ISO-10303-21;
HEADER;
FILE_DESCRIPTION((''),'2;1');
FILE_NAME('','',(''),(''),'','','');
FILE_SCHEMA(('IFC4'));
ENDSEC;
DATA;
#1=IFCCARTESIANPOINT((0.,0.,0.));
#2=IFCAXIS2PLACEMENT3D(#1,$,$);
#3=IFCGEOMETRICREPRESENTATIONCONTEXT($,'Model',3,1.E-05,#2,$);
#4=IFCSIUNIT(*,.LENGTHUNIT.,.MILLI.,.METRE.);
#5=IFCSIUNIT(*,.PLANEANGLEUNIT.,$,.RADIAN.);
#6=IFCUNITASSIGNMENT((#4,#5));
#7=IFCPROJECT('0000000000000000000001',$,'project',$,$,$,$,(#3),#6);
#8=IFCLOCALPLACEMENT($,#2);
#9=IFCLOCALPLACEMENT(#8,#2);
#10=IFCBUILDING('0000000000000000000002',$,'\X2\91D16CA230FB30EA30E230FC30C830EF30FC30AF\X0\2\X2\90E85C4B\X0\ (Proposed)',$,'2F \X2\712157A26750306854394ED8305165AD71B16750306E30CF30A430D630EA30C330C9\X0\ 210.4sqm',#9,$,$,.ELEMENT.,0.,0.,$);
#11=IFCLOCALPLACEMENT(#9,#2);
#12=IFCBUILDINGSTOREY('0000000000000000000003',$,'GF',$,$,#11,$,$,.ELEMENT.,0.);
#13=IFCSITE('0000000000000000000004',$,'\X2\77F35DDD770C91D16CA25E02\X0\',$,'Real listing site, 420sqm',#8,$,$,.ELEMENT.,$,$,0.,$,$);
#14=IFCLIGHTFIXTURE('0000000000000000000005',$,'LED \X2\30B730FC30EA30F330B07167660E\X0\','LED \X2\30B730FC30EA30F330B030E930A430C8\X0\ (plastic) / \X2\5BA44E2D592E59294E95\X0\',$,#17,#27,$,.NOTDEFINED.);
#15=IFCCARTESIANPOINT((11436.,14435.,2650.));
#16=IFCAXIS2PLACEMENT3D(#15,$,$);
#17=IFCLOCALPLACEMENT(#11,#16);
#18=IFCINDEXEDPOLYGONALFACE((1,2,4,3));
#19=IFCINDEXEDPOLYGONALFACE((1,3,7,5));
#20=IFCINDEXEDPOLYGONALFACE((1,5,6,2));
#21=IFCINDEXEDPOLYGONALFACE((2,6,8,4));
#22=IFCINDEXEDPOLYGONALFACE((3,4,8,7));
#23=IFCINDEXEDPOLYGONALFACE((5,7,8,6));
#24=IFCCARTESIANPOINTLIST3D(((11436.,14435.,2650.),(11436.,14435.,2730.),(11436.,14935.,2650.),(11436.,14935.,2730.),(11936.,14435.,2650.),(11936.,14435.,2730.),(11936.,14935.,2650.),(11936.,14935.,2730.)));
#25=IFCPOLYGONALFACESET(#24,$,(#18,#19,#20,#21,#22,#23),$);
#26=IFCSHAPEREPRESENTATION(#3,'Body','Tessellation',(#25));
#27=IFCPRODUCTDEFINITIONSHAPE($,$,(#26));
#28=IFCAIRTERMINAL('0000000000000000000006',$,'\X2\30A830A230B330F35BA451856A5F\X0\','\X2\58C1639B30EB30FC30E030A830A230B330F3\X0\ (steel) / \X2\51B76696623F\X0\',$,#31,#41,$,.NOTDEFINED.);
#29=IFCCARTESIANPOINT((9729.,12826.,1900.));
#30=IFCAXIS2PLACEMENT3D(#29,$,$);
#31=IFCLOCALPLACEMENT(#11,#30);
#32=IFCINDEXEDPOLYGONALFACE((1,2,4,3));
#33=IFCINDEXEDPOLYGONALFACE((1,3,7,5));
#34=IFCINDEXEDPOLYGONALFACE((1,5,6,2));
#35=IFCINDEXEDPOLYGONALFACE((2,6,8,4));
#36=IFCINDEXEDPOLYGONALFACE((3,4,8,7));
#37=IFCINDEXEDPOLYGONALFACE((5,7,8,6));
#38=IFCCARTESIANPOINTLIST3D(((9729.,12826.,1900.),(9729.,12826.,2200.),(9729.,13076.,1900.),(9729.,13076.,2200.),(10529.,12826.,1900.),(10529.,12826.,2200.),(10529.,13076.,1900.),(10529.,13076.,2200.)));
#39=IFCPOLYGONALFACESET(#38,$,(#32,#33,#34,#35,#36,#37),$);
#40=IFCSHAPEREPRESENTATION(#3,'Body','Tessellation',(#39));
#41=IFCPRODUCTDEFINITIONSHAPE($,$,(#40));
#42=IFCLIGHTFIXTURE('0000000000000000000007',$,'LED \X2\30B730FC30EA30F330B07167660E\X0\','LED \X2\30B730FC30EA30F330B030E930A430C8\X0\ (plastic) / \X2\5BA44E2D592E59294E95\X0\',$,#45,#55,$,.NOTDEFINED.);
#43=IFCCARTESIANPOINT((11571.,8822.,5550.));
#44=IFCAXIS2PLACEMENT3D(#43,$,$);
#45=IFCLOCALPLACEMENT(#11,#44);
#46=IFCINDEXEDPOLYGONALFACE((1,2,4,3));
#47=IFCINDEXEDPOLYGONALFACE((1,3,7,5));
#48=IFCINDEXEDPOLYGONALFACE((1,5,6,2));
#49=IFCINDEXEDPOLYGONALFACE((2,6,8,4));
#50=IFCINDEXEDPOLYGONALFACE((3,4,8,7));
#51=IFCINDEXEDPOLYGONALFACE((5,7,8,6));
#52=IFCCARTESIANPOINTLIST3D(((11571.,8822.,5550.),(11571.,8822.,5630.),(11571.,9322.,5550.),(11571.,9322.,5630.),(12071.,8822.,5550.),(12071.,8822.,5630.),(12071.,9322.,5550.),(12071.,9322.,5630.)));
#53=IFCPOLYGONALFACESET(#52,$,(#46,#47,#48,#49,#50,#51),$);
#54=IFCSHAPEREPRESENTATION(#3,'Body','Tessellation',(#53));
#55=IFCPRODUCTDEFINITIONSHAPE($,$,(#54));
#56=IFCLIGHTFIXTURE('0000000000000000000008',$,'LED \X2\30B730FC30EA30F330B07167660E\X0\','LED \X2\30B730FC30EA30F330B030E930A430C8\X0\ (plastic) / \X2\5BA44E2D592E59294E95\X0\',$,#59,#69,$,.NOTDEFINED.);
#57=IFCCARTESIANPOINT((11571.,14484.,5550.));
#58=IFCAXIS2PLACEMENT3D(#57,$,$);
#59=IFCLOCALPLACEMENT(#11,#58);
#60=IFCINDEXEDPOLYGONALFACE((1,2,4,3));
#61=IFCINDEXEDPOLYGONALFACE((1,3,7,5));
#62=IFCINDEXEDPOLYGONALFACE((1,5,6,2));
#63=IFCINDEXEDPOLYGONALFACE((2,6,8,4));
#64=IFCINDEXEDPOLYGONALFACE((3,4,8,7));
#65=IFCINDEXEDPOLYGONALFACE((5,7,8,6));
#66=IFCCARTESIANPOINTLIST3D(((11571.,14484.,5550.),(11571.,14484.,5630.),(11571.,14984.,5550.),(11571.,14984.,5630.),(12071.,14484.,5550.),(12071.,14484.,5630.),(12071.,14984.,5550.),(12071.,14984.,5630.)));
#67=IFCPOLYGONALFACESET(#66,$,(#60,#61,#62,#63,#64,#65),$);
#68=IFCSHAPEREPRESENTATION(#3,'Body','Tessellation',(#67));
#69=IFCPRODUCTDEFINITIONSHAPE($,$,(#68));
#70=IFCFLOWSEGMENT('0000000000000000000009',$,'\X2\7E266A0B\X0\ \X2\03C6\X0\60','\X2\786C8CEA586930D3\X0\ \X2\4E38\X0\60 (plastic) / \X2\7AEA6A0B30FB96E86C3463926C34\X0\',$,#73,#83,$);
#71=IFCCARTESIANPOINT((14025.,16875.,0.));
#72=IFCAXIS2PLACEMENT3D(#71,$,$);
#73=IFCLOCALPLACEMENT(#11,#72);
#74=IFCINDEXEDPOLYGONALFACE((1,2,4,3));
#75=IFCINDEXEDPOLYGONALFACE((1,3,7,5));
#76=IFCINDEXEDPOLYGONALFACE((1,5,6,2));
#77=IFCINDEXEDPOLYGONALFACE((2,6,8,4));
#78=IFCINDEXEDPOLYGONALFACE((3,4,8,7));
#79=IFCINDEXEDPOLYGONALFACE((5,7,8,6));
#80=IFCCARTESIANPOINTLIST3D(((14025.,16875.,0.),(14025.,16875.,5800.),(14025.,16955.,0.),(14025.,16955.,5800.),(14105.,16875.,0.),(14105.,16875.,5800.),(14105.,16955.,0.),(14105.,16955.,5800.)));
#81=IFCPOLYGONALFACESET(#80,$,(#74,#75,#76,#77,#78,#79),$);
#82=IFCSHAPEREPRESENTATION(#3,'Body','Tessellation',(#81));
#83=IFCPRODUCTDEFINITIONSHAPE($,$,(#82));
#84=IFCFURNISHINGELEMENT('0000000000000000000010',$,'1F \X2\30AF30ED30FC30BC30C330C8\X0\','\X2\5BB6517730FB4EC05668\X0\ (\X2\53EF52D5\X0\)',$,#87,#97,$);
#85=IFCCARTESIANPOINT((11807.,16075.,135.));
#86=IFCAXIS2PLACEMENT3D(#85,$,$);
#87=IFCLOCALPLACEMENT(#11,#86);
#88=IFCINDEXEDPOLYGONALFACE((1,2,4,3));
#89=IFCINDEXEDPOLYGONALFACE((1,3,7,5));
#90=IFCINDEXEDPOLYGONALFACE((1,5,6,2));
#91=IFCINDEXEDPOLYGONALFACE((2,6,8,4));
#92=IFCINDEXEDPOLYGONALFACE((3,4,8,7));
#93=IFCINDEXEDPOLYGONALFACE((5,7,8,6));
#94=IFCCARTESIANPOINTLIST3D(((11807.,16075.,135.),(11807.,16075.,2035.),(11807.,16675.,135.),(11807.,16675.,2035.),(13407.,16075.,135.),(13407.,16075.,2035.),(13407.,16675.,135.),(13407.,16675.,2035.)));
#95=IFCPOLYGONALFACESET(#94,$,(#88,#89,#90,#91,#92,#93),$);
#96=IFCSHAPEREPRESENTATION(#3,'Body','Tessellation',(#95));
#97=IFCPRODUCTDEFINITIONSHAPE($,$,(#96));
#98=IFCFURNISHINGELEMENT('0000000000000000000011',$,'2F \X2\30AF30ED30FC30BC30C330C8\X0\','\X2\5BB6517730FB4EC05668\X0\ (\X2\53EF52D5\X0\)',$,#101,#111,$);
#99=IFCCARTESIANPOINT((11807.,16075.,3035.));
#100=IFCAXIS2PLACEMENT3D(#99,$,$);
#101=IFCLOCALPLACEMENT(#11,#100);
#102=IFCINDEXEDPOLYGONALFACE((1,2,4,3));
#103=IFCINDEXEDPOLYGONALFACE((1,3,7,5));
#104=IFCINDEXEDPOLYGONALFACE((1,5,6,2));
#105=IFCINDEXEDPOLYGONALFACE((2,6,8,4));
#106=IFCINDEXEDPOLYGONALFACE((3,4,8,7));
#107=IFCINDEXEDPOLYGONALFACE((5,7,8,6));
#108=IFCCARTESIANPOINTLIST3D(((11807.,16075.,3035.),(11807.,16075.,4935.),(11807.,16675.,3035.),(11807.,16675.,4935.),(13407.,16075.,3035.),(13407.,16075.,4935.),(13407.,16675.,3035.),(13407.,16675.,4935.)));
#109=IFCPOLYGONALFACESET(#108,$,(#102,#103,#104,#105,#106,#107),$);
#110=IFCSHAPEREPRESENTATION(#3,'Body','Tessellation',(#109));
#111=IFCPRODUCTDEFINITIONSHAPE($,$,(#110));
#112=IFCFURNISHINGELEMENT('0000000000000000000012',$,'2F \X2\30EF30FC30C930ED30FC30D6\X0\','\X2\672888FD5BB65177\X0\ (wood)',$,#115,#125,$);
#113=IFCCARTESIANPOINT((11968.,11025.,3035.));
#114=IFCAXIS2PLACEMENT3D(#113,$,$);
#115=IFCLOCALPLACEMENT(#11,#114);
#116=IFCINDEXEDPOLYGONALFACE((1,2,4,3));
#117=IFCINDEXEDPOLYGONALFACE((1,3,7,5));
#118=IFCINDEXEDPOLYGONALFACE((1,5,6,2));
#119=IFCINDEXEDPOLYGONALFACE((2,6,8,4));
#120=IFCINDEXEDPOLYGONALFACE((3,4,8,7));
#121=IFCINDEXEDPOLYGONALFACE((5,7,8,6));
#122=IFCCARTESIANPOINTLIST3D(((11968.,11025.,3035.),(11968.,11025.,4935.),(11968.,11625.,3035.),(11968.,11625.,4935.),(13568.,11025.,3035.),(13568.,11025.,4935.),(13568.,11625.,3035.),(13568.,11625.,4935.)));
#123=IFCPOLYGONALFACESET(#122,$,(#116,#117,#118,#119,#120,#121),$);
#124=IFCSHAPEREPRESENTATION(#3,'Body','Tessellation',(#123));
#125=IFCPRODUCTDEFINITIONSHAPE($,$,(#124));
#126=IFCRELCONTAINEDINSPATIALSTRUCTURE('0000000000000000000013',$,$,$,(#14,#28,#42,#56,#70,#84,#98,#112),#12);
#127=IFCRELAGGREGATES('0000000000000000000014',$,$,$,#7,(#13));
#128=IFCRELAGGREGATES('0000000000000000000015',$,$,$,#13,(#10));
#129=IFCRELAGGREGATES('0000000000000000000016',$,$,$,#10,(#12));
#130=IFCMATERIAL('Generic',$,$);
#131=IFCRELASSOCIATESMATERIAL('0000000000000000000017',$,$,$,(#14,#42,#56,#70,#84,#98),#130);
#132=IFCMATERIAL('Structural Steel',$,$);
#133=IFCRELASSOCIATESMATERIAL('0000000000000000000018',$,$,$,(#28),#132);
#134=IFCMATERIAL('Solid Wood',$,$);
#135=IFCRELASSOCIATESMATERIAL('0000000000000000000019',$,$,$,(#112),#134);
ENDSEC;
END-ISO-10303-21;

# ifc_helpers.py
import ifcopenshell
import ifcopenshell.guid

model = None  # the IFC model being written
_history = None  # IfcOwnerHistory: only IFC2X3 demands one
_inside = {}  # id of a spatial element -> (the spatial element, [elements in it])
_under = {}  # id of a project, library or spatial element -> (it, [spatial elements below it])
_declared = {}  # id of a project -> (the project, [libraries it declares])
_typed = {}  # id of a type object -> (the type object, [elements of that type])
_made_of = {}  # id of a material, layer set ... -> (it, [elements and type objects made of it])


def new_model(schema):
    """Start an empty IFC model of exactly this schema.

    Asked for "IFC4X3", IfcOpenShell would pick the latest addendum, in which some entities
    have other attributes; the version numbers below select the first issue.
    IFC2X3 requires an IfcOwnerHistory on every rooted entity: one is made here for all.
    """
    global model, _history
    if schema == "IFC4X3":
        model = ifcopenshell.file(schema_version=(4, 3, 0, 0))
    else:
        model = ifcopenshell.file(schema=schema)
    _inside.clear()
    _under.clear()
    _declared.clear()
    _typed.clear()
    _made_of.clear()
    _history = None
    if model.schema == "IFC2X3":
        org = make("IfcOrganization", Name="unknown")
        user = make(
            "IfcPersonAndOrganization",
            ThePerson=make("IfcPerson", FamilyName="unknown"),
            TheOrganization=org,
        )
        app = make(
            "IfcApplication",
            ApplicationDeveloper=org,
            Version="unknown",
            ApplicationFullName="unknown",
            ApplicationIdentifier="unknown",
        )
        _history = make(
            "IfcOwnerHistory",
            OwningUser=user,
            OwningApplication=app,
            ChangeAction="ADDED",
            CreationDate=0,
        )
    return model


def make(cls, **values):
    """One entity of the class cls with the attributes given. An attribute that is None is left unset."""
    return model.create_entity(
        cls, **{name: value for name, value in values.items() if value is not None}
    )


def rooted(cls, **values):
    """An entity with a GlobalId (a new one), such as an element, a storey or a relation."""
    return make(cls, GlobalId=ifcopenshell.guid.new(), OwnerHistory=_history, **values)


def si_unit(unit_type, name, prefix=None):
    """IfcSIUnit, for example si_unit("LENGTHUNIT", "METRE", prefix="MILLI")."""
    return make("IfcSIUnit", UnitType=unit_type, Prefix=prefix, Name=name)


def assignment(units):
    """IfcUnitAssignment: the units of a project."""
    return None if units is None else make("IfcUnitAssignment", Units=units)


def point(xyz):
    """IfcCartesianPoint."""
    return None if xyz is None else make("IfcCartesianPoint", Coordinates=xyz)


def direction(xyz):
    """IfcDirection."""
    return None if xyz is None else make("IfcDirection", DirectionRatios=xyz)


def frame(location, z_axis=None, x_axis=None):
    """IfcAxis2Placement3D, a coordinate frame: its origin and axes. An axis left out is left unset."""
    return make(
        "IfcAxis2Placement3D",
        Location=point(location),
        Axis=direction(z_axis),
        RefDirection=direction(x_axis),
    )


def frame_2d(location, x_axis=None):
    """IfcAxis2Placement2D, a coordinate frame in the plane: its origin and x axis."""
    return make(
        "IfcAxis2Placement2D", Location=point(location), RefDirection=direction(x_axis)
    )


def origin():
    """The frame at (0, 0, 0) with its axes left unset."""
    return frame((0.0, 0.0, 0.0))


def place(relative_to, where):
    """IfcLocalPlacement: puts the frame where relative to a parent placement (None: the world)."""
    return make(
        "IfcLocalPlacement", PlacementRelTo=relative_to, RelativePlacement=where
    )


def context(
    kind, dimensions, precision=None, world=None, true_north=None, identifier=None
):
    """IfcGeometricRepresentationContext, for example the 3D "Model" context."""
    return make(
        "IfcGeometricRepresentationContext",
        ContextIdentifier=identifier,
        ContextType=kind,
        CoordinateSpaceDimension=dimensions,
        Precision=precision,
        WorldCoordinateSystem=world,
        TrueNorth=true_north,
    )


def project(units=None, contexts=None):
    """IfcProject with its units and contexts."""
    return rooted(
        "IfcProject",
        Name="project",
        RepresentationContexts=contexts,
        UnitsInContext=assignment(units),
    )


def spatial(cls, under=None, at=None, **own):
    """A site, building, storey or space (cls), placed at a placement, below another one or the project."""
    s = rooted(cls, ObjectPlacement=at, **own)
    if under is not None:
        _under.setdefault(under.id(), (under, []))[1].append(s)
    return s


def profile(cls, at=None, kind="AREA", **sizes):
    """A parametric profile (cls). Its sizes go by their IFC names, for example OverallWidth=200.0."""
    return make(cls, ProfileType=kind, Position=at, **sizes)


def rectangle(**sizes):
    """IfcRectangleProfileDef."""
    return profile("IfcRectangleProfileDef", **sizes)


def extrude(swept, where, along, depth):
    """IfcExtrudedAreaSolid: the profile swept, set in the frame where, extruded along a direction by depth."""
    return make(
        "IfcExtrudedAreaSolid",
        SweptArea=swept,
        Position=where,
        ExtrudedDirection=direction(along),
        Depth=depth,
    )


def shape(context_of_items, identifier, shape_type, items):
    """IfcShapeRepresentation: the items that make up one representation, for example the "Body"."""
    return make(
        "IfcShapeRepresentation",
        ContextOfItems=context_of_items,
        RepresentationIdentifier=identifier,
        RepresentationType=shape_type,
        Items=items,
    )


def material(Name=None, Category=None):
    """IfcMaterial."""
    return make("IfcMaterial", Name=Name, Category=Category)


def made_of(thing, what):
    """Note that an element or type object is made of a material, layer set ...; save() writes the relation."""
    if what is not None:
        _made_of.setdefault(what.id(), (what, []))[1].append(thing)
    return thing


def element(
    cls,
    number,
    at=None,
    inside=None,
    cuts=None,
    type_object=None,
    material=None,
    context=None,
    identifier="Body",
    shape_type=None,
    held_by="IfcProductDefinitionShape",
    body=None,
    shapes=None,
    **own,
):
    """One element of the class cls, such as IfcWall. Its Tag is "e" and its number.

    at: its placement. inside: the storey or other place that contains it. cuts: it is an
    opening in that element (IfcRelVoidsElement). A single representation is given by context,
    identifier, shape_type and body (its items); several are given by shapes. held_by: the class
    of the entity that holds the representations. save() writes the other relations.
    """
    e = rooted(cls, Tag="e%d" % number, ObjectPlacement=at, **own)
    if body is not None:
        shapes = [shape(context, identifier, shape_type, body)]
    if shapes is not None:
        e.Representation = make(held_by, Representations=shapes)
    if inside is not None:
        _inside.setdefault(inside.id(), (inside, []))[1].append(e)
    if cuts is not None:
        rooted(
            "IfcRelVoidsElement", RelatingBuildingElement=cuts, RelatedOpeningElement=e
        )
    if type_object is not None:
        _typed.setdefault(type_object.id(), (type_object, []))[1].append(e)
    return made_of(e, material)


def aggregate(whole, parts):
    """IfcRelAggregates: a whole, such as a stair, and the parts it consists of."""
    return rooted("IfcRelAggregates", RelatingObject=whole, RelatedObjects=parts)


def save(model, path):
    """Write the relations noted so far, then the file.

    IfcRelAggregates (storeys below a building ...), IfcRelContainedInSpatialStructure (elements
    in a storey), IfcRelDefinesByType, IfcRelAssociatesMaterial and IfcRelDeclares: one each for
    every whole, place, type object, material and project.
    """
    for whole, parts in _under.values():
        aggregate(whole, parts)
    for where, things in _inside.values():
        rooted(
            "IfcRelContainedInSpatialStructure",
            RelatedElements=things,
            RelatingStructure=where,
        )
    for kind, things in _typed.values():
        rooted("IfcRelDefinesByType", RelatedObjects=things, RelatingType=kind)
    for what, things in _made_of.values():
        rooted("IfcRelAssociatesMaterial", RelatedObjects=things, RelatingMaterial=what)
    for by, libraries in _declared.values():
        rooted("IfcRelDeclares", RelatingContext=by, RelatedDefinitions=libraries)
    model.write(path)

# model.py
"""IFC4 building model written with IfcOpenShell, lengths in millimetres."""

from ifc_helpers import new_model, si_unit, frame, frame_2d, origin, place, context, project, spatial, rectangle, extrude, material, element, save


model = new_model("IFC4")

# Units and contexts
model_context = context("Model", 3, precision=1e-05, world=origin())
ifc_project = project(units=[si_unit("LENGTHUNIT", "METRE", prefix="MILLI"), si_unit("PLANEANGLEUNIT", "RADIAN")], contexts=[model_context])

# Site, building, storey
site_placement = place(None, origin())
site = spatial("IfcSite", under=ifc_project, at=site_placement, Name="石川県金沢市", ObjectType="Real listing site, 420sqm", CompositionType="ELEMENT", RefElevation=0.0)
building_placement = place(site_placement, origin())
building = spatial("IfcBuilding", under=site, at=building_placement, Name="金沢・リモートワーク2部屋 (Proposed)", ObjectType="2F 無垢材と吹付け断熱材のハイブリッド 210.4sqm", CompositionType="ELEMENT", ElevationOfRefHeight=0.0, ElevationOfTerrain=0.0)
storey_placement = place(building_placement, origin())
storey = spatial("IfcBuildingStorey", under=building, at=storey_placement, Name="GF", CompositionType="ELEMENT", Elevation=0.0)

# Shared definitions
ifc_material_1 = material(Name="Solid Wood")

# Shared definitions
ifc_material_2 = material(Name="Structural Steel")

# Shared definitions
ifc_material_3 = material(Name="Generic")

# Light fixture
light_fixture_1_placement = place(storey_placement, frame((11436.0, 14435.0, 2650.0)))
element("IfcLightFixture", 1, at=light_fixture_1_placement, inside=storey, material=ifc_material_3, Name="LED シーリング照明", Description="LED シーリングライト (plastic) / 室中央天井", PredefinedType="NOTDEFINED", context=model_context, shape_type="SweptSolid", body=[
    extrude(rectangle(XDim=500.0, YDim=500.0, at=frame_2d((250.0, 250.0))), frame((11436.0, 14435.0, 2650.0)), (0.0, 0.0, 1.0), 80.0),
])

# Air terminal
air_terminal_placement = place(storey_placement, frame((9729.0, 12826.0, 1900.0)))
element("IfcAirTerminal", 2, at=air_terminal_placement, inside=storey, material=ifc_material_2, Name="エアコン室内機", Description="壁掛ルームエアコン (steel) / 冷暖房", PredefinedType="NOTDEFINED", context=model_context, shape_type="SweptSolid", body=[
    extrude(rectangle(XDim=800.0, YDim=250.0, at=frame_2d((400.0, 125.0))), frame((9729.0, 12826.0, 1900.0)), (0.0, 0.0, 1.0), 300.0),
])

# Light fixtures
light_fixture_2_placement = place(storey_placement, frame((11571.0, 8822.0, 5550.0)))
element("IfcLightFixture", 3, at=light_fixture_2_placement, inside=storey, material=ifc_material_3, Name="LED シーリング照明", Description="LED シーリングライト (plastic) / 室中央天井", PredefinedType="NOTDEFINED", context=model_context, shape_type="SweptSolid", body=[
    extrude(rectangle(XDim=500.0, YDim=500.0, at=frame_2d((250.0, 250.0))), frame((11571.0, 8822.0, 5550.0)), (0.0, 0.0, 1.0), 80.0),
])
light_fixture_3_placement = place(storey_placement, frame((11571.0, 14484.0, 5550.0)))
element("IfcLightFixture", 4, at=light_fixture_3_placement, inside=storey, material=ifc_material_3, Name="LED シーリング照明", Description="LED シーリングライト (plastic) / 室中央天井", PredefinedType="NOTDEFINED", context=model_context, shape_type="SweptSolid", body=[
    extrude(rectangle(XDim=500.0, YDim=500.0, at=frame_2d((250.0, 250.0))), frame((11571.0, 14484.0, 5550.0)), (0.0, 0.0, 1.0), 80.0),
])

# Flow segment
flow_segment_placement = place(storey_placement, frame((14025.0, 16875.0, 0.0)))
element("IfcFlowSegment", 5, at=flow_segment_placement, inside=storey, material=ifc_material_3, Name="縦樋 φ60", Description="硬質塩ビ 丸60 (plastic) / 竪樋・雨水排水", context=model_context, shape_type="SweptSolid", body=[
    extrude(rectangle(XDim=80.0, YDim=80.0, at=frame_2d((40.0, 40.0))), frame((14025.0, 16875.0, 0.0)), (0.0, 0.0, 1.0), 5800.0),
])

# Furnishing elements
furnishing_1_placement = place(storey_placement, frame((11807.0, 16075.0, 135.0)))
element("IfcFurnishingElement", 6, at=furnishing_1_placement, inside=storey, material=ifc_material_3, Name="1F クローゼット", Description="家具・什器 (可動)", context=model_context, shape_type="SweptSolid", body=[
    extrude(rectangle(XDim=1600.0, YDim=600.0, at=frame_2d((800.0, 300.0))), frame((11807.0, 16075.0, 135.0)), (0.0, 0.0, 1.0), 1900.0),
])
furnishing_2_placement = place(storey_placement, frame((11807.0, 16075.0, 3035.0)))
element("IfcFurnishingElement", 7, at=furnishing_2_placement, inside=storey, material=ifc_material_3, Name="2F クローゼット", Description="家具・什器 (可動)", context=model_context, shape_type="SweptSolid", body=[
    extrude(rectangle(XDim=1600.0, YDim=600.0, at=frame_2d((800.0, 300.0))), frame((11807.0, 16075.0, 3035.0)), (0.0, 0.0, 1.0), 1900.0),
])
furnishing_3_placement = place(storey_placement, frame((11968.0, 11025.0, 3035.0)))
element("IfcFurnishingElement", 8, at=furnishing_3_placement, inside=storey, material=ifc_material_1, Name="2F ワードローブ", Description="木製家具 (wood)", context=model_context, shape_type="SweptSolid", body=[
    extrude(rectangle(XDim=1600.0, YDim=600.0, at=frame_2d((800.0, 300.0))), frame((11968.0, 11025.0, 3035.0)), (0.0, 0.0, 1.0), 1900.0),
])

save(model, "model.ifc")
